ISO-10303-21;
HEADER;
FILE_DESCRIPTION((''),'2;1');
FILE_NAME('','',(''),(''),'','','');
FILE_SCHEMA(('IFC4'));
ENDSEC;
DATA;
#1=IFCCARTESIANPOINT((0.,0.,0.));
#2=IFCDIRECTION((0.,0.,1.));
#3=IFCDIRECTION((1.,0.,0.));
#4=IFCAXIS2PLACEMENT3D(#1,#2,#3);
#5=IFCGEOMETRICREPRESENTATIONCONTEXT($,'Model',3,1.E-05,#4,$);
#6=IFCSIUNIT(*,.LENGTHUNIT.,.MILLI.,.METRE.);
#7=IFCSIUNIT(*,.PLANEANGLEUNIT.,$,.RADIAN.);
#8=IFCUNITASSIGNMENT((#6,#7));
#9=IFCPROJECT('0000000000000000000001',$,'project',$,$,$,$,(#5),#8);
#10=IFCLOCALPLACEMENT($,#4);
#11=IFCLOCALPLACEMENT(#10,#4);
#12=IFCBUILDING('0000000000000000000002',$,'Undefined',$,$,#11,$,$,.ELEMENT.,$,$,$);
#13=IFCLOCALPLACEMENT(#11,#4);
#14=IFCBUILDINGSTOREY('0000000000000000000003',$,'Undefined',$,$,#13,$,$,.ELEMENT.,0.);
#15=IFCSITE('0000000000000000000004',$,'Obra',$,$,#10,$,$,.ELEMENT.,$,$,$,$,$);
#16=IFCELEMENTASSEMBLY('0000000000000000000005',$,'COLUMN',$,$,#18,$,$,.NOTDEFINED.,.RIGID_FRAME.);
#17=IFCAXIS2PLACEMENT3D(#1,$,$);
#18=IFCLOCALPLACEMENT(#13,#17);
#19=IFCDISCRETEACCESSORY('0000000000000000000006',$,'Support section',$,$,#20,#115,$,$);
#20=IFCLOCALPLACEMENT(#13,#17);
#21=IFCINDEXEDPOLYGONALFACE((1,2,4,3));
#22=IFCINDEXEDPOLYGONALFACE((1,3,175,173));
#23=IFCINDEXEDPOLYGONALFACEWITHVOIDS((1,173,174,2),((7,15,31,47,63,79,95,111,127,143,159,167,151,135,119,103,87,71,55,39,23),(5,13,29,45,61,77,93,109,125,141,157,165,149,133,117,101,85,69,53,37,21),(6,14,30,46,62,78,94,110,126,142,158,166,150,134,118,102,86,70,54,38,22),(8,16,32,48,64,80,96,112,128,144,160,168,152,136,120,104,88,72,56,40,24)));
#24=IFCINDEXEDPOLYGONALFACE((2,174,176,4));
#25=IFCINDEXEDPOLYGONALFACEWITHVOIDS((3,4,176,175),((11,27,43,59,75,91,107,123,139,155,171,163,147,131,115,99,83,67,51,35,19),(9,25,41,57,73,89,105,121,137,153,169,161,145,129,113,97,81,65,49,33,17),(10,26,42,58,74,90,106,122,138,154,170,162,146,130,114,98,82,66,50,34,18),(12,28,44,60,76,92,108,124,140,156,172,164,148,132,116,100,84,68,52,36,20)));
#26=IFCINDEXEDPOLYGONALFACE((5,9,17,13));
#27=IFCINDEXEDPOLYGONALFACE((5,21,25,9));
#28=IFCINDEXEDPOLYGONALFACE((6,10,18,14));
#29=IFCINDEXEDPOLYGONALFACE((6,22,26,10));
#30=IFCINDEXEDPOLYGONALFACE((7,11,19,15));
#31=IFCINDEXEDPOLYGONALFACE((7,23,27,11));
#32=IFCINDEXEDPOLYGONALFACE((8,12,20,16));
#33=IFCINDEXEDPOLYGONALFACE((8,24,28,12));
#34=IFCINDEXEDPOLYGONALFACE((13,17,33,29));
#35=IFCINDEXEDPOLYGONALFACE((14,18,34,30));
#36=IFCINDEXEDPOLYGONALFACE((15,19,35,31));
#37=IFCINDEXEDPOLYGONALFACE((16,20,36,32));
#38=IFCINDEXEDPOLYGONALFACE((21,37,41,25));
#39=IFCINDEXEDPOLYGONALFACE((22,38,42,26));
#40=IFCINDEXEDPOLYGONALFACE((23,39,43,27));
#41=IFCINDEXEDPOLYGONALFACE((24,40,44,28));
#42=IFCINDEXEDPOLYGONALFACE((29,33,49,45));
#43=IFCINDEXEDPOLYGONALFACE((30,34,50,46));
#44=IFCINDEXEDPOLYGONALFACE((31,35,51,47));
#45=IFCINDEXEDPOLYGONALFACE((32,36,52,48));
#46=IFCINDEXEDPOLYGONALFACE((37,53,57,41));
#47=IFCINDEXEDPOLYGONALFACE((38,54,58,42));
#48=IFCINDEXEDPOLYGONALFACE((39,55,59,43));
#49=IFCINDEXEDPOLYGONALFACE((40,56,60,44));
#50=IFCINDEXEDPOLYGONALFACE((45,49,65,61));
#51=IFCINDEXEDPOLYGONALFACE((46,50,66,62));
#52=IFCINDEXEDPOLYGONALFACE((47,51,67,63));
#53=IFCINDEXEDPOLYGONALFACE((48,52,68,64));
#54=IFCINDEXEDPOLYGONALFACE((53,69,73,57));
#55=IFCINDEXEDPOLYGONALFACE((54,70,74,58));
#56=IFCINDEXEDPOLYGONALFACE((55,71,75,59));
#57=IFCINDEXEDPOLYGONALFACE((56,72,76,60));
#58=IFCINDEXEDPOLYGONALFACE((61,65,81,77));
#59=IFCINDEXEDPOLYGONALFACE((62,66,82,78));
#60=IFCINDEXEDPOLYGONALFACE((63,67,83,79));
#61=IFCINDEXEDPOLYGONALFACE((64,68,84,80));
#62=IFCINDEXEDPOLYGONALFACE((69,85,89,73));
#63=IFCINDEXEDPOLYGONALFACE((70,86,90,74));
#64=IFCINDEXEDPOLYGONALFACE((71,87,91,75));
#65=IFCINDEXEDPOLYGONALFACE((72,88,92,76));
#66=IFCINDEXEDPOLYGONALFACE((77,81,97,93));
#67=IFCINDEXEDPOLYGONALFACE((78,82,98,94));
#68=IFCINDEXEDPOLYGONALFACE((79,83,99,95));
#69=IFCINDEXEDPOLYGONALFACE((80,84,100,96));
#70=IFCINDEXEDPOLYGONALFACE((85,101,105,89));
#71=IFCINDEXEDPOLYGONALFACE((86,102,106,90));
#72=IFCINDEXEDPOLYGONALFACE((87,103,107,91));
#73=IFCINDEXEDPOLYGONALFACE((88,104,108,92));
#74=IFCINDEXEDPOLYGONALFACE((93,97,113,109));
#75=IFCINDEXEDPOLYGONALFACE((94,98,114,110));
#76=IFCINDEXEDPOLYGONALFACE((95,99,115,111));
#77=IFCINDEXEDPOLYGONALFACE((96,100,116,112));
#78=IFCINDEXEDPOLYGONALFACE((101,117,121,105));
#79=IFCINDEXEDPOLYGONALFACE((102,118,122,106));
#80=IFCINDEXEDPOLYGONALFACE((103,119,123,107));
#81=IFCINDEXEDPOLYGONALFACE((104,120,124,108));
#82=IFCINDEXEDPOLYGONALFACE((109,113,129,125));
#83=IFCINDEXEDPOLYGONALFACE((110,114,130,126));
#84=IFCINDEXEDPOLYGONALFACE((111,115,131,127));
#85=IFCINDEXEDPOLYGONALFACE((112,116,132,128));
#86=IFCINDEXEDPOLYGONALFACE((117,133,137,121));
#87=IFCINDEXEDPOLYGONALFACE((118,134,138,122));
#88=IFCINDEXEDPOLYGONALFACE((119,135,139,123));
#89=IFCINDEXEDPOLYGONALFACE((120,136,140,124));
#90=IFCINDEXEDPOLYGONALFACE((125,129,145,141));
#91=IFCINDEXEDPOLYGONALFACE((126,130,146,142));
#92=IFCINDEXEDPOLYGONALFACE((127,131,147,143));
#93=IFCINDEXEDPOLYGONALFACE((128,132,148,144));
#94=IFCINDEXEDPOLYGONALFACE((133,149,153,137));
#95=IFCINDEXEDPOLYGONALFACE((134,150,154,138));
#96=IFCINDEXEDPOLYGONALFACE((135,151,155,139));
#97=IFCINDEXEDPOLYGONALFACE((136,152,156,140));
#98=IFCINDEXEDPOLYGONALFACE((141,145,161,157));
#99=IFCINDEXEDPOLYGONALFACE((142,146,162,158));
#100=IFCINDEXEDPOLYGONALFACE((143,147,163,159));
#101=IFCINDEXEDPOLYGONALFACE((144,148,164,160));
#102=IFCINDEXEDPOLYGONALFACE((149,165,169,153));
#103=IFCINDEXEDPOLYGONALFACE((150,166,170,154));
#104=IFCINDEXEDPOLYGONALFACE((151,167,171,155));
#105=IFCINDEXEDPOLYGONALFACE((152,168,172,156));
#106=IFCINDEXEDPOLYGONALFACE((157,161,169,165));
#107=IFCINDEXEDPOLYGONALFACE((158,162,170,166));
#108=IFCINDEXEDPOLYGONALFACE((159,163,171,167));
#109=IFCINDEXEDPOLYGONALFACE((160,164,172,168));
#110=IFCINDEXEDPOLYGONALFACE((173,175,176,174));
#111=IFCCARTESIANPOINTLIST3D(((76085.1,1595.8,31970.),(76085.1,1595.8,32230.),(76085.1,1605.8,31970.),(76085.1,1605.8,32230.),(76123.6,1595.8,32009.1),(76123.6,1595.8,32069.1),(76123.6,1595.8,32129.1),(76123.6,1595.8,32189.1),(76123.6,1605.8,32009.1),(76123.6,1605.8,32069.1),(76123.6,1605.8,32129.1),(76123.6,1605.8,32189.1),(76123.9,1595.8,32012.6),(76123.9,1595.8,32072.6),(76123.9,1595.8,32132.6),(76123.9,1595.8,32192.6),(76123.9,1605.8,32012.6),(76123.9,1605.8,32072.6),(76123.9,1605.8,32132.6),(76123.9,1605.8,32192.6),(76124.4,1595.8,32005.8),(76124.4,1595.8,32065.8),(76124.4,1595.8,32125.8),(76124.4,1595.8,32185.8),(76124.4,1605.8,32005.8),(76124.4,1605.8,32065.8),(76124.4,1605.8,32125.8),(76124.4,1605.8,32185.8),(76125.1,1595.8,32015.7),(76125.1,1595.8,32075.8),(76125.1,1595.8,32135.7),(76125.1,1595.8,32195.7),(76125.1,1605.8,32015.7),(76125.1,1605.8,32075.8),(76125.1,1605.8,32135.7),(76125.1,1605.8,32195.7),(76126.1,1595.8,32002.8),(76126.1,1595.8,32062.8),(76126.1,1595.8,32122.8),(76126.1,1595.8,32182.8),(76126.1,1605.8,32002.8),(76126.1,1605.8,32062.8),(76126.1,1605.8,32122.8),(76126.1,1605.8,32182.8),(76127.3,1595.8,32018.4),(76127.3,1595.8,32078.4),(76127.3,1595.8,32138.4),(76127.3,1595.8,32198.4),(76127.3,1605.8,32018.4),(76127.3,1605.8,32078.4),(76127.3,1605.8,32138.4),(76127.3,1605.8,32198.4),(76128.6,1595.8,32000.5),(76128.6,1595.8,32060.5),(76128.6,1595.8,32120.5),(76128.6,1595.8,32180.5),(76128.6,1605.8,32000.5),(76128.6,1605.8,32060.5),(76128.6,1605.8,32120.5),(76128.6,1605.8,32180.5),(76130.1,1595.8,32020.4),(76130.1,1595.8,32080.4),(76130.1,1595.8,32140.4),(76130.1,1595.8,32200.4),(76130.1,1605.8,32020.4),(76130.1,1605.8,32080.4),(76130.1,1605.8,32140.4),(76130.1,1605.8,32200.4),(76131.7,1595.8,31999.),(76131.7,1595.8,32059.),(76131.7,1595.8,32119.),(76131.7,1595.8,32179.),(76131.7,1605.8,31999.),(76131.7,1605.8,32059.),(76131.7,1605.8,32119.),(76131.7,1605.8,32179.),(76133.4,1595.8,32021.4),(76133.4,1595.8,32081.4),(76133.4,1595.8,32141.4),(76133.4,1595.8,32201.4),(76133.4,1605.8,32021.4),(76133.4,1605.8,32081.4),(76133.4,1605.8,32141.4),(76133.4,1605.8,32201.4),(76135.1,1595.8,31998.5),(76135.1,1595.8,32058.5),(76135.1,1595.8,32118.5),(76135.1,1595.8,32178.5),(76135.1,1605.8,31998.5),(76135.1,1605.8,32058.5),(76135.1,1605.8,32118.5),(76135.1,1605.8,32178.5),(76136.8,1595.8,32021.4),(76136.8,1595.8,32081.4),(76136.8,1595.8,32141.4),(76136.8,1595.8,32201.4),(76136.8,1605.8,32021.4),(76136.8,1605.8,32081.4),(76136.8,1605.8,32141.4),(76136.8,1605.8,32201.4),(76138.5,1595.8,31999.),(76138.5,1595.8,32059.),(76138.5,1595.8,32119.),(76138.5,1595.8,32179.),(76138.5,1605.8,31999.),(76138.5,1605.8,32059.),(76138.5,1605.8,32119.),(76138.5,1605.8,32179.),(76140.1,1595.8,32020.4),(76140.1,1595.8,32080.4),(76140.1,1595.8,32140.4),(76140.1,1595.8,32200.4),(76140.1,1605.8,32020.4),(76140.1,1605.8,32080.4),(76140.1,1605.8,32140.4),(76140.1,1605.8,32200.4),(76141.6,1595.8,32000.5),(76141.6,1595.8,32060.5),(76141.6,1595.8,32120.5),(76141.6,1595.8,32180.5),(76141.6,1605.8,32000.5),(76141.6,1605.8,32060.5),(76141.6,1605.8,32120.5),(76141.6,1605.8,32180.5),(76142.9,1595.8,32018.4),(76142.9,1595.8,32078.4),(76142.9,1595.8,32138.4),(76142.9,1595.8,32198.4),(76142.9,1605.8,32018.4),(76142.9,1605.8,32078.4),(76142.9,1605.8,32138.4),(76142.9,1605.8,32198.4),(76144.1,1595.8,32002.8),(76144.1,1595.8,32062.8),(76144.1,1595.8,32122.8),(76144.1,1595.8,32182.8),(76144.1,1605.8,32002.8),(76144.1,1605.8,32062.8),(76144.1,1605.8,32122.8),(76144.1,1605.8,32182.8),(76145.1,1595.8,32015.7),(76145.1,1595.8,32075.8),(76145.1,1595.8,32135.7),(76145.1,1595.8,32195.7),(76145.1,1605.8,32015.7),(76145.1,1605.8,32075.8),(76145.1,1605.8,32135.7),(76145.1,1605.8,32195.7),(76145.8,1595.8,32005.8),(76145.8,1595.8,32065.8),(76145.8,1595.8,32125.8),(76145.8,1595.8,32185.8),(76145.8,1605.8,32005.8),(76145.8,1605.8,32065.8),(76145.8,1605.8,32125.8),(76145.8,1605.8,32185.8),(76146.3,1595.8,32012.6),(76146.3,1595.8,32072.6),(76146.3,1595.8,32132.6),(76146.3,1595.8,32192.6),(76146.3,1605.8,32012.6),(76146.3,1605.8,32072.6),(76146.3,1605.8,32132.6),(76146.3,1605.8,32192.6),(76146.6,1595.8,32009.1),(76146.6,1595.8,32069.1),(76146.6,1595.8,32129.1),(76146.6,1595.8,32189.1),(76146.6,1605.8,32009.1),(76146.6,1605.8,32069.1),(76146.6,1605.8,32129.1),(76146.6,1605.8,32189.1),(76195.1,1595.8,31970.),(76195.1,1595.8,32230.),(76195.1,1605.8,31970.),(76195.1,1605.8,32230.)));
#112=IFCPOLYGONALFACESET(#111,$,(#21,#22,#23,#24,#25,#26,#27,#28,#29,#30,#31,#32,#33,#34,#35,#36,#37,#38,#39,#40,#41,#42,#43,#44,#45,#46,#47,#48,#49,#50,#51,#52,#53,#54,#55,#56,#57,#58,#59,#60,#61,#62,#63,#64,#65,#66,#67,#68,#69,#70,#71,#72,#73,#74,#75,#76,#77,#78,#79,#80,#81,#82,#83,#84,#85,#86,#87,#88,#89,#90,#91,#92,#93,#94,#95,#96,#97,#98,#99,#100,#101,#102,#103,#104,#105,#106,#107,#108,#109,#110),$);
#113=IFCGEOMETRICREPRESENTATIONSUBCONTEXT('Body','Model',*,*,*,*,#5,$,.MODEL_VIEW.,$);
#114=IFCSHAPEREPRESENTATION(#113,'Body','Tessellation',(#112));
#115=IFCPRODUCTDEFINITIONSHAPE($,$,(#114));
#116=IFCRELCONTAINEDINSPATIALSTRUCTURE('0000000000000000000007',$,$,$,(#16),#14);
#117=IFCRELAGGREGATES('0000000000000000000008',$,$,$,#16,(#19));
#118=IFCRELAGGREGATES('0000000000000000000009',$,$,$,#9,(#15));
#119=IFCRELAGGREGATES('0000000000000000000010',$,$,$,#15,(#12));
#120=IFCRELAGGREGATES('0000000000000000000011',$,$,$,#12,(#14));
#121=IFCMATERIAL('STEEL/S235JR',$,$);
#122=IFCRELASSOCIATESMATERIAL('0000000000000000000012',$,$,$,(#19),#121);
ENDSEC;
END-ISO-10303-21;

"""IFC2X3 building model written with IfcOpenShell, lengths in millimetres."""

from ifc_helpers import new_model, si_unit, frame, origin_with_axes, origin_2d_with_axis, place, context, subcontext, project, spatial, rectangle, circle, extrude, source, transform, mapped, material, element, aggregate, save


model = new_model("IFC2X3")

# Units and contexts
model_context = context("Model", 3, precision=1e-05, world=origin_with_axes())
body_context = subcontext(model_context, "Body", "Model", "MODEL_VIEW")
ifc_project = project(units=[si_unit("LENGTHUNIT", "METRE", prefix="MILLI"), si_unit("PLANEANGLEUNIT", "RADIAN")], contexts=[model_context])

# Site, building, storey
site_placement = place(None, origin_with_axes())
site = spatial("IfcSite", under=ifc_project, at=site_placement, Name="Obra", CompositionType="ELEMENT")
building_placement = place(site_placement, origin_with_axes())
building = spatial("IfcBuilding", under=site, at=building_placement, Name="Undefined", CompositionType="ELEMENT")
storey_placement = place(building_placement, origin_with_axes())
storey = spatial("IfcBuildingStorey", under=building, at=storey_placement, Name="Undefined", CompositionType="ELEMENT", Elevation=0.0)

# Shared definitions
ifc_material_1 = material(Name="STEEL/S235JR")

# Element assembly, discrete accessory, opening
assembly_1_placement = place(storey_placement, origin_with_axes())
assembly_1 = element("IfcElementAssembly", 1, at=assembly_1_placement, inside=storey, Name="COLUMN", AssemblyPlace="NOTDEFINED", PredefinedType="RIGID_FRAME")
discrete_accessory_1_placement = place(assembly_1_placement, frame((76140.1, 1600.8, 31970.0), z_axis=(0.0, 0.0, 1.0), x_axis=(1.0, 0.0, 0.0)))
discrete_accessory_1 = element("IfcDiscreteAccessory", 2, at=discrete_accessory_1_placement, material=ifc_material_1, Name="Support section", context=body_context, shape_type="SweptSolid", body=[
    extrude(rectangle(XDim=10.0, YDim=110.0, at=origin_2d_with_axis()), frame((0.0, 0.0, 260.0), z_axis=(0.0, 0.0, -1.0), x_axis=(0.0, 1.0, 0.0)), (0.0, 0.0, 1.0), 260.0),
])
shared_shape_1 = source(origin_with_axes(), body_context, "Body", "SweptSolid", [
    extrude(circle(Radius=11.5, at=origin_2d_with_axis()), frame((0.0, -14.4, 0.0), z_axis=(0.0, 1.0, 0.0), x_axis=(1.0, 0.0, 0.0)), (0.0, 0.0, 1.0), 10.2),
])
opening_1_placement = place(assembly_1_placement, frame((76185.1, 1591.5, 32300.0), z_axis=(-1.0, 0.0, 0.0), x_axis=(0.0, 0.0, -1.0)))
element("IfcOpeningElement", 3, at=opening_1_placement, cuts=discrete_accessory_1, ObjectType="Opening", context=body_context, shape_type="MappedRepresentation", body=[
    mapped(shared_shape_1, transform((110.0, 0.0, 50.0))),
    mapped(shared_shape_1, transform((170.0, 0.0, 50.0))),
    mapped(shared_shape_1, transform((230.0, 0.0, 50.0))),
    mapped(shared_shape_1, transform((290.0, 0.0, 50.0))),
])
aggregate(assembly_1, [discrete_accessory_1])

save(model, "model.ifc")
